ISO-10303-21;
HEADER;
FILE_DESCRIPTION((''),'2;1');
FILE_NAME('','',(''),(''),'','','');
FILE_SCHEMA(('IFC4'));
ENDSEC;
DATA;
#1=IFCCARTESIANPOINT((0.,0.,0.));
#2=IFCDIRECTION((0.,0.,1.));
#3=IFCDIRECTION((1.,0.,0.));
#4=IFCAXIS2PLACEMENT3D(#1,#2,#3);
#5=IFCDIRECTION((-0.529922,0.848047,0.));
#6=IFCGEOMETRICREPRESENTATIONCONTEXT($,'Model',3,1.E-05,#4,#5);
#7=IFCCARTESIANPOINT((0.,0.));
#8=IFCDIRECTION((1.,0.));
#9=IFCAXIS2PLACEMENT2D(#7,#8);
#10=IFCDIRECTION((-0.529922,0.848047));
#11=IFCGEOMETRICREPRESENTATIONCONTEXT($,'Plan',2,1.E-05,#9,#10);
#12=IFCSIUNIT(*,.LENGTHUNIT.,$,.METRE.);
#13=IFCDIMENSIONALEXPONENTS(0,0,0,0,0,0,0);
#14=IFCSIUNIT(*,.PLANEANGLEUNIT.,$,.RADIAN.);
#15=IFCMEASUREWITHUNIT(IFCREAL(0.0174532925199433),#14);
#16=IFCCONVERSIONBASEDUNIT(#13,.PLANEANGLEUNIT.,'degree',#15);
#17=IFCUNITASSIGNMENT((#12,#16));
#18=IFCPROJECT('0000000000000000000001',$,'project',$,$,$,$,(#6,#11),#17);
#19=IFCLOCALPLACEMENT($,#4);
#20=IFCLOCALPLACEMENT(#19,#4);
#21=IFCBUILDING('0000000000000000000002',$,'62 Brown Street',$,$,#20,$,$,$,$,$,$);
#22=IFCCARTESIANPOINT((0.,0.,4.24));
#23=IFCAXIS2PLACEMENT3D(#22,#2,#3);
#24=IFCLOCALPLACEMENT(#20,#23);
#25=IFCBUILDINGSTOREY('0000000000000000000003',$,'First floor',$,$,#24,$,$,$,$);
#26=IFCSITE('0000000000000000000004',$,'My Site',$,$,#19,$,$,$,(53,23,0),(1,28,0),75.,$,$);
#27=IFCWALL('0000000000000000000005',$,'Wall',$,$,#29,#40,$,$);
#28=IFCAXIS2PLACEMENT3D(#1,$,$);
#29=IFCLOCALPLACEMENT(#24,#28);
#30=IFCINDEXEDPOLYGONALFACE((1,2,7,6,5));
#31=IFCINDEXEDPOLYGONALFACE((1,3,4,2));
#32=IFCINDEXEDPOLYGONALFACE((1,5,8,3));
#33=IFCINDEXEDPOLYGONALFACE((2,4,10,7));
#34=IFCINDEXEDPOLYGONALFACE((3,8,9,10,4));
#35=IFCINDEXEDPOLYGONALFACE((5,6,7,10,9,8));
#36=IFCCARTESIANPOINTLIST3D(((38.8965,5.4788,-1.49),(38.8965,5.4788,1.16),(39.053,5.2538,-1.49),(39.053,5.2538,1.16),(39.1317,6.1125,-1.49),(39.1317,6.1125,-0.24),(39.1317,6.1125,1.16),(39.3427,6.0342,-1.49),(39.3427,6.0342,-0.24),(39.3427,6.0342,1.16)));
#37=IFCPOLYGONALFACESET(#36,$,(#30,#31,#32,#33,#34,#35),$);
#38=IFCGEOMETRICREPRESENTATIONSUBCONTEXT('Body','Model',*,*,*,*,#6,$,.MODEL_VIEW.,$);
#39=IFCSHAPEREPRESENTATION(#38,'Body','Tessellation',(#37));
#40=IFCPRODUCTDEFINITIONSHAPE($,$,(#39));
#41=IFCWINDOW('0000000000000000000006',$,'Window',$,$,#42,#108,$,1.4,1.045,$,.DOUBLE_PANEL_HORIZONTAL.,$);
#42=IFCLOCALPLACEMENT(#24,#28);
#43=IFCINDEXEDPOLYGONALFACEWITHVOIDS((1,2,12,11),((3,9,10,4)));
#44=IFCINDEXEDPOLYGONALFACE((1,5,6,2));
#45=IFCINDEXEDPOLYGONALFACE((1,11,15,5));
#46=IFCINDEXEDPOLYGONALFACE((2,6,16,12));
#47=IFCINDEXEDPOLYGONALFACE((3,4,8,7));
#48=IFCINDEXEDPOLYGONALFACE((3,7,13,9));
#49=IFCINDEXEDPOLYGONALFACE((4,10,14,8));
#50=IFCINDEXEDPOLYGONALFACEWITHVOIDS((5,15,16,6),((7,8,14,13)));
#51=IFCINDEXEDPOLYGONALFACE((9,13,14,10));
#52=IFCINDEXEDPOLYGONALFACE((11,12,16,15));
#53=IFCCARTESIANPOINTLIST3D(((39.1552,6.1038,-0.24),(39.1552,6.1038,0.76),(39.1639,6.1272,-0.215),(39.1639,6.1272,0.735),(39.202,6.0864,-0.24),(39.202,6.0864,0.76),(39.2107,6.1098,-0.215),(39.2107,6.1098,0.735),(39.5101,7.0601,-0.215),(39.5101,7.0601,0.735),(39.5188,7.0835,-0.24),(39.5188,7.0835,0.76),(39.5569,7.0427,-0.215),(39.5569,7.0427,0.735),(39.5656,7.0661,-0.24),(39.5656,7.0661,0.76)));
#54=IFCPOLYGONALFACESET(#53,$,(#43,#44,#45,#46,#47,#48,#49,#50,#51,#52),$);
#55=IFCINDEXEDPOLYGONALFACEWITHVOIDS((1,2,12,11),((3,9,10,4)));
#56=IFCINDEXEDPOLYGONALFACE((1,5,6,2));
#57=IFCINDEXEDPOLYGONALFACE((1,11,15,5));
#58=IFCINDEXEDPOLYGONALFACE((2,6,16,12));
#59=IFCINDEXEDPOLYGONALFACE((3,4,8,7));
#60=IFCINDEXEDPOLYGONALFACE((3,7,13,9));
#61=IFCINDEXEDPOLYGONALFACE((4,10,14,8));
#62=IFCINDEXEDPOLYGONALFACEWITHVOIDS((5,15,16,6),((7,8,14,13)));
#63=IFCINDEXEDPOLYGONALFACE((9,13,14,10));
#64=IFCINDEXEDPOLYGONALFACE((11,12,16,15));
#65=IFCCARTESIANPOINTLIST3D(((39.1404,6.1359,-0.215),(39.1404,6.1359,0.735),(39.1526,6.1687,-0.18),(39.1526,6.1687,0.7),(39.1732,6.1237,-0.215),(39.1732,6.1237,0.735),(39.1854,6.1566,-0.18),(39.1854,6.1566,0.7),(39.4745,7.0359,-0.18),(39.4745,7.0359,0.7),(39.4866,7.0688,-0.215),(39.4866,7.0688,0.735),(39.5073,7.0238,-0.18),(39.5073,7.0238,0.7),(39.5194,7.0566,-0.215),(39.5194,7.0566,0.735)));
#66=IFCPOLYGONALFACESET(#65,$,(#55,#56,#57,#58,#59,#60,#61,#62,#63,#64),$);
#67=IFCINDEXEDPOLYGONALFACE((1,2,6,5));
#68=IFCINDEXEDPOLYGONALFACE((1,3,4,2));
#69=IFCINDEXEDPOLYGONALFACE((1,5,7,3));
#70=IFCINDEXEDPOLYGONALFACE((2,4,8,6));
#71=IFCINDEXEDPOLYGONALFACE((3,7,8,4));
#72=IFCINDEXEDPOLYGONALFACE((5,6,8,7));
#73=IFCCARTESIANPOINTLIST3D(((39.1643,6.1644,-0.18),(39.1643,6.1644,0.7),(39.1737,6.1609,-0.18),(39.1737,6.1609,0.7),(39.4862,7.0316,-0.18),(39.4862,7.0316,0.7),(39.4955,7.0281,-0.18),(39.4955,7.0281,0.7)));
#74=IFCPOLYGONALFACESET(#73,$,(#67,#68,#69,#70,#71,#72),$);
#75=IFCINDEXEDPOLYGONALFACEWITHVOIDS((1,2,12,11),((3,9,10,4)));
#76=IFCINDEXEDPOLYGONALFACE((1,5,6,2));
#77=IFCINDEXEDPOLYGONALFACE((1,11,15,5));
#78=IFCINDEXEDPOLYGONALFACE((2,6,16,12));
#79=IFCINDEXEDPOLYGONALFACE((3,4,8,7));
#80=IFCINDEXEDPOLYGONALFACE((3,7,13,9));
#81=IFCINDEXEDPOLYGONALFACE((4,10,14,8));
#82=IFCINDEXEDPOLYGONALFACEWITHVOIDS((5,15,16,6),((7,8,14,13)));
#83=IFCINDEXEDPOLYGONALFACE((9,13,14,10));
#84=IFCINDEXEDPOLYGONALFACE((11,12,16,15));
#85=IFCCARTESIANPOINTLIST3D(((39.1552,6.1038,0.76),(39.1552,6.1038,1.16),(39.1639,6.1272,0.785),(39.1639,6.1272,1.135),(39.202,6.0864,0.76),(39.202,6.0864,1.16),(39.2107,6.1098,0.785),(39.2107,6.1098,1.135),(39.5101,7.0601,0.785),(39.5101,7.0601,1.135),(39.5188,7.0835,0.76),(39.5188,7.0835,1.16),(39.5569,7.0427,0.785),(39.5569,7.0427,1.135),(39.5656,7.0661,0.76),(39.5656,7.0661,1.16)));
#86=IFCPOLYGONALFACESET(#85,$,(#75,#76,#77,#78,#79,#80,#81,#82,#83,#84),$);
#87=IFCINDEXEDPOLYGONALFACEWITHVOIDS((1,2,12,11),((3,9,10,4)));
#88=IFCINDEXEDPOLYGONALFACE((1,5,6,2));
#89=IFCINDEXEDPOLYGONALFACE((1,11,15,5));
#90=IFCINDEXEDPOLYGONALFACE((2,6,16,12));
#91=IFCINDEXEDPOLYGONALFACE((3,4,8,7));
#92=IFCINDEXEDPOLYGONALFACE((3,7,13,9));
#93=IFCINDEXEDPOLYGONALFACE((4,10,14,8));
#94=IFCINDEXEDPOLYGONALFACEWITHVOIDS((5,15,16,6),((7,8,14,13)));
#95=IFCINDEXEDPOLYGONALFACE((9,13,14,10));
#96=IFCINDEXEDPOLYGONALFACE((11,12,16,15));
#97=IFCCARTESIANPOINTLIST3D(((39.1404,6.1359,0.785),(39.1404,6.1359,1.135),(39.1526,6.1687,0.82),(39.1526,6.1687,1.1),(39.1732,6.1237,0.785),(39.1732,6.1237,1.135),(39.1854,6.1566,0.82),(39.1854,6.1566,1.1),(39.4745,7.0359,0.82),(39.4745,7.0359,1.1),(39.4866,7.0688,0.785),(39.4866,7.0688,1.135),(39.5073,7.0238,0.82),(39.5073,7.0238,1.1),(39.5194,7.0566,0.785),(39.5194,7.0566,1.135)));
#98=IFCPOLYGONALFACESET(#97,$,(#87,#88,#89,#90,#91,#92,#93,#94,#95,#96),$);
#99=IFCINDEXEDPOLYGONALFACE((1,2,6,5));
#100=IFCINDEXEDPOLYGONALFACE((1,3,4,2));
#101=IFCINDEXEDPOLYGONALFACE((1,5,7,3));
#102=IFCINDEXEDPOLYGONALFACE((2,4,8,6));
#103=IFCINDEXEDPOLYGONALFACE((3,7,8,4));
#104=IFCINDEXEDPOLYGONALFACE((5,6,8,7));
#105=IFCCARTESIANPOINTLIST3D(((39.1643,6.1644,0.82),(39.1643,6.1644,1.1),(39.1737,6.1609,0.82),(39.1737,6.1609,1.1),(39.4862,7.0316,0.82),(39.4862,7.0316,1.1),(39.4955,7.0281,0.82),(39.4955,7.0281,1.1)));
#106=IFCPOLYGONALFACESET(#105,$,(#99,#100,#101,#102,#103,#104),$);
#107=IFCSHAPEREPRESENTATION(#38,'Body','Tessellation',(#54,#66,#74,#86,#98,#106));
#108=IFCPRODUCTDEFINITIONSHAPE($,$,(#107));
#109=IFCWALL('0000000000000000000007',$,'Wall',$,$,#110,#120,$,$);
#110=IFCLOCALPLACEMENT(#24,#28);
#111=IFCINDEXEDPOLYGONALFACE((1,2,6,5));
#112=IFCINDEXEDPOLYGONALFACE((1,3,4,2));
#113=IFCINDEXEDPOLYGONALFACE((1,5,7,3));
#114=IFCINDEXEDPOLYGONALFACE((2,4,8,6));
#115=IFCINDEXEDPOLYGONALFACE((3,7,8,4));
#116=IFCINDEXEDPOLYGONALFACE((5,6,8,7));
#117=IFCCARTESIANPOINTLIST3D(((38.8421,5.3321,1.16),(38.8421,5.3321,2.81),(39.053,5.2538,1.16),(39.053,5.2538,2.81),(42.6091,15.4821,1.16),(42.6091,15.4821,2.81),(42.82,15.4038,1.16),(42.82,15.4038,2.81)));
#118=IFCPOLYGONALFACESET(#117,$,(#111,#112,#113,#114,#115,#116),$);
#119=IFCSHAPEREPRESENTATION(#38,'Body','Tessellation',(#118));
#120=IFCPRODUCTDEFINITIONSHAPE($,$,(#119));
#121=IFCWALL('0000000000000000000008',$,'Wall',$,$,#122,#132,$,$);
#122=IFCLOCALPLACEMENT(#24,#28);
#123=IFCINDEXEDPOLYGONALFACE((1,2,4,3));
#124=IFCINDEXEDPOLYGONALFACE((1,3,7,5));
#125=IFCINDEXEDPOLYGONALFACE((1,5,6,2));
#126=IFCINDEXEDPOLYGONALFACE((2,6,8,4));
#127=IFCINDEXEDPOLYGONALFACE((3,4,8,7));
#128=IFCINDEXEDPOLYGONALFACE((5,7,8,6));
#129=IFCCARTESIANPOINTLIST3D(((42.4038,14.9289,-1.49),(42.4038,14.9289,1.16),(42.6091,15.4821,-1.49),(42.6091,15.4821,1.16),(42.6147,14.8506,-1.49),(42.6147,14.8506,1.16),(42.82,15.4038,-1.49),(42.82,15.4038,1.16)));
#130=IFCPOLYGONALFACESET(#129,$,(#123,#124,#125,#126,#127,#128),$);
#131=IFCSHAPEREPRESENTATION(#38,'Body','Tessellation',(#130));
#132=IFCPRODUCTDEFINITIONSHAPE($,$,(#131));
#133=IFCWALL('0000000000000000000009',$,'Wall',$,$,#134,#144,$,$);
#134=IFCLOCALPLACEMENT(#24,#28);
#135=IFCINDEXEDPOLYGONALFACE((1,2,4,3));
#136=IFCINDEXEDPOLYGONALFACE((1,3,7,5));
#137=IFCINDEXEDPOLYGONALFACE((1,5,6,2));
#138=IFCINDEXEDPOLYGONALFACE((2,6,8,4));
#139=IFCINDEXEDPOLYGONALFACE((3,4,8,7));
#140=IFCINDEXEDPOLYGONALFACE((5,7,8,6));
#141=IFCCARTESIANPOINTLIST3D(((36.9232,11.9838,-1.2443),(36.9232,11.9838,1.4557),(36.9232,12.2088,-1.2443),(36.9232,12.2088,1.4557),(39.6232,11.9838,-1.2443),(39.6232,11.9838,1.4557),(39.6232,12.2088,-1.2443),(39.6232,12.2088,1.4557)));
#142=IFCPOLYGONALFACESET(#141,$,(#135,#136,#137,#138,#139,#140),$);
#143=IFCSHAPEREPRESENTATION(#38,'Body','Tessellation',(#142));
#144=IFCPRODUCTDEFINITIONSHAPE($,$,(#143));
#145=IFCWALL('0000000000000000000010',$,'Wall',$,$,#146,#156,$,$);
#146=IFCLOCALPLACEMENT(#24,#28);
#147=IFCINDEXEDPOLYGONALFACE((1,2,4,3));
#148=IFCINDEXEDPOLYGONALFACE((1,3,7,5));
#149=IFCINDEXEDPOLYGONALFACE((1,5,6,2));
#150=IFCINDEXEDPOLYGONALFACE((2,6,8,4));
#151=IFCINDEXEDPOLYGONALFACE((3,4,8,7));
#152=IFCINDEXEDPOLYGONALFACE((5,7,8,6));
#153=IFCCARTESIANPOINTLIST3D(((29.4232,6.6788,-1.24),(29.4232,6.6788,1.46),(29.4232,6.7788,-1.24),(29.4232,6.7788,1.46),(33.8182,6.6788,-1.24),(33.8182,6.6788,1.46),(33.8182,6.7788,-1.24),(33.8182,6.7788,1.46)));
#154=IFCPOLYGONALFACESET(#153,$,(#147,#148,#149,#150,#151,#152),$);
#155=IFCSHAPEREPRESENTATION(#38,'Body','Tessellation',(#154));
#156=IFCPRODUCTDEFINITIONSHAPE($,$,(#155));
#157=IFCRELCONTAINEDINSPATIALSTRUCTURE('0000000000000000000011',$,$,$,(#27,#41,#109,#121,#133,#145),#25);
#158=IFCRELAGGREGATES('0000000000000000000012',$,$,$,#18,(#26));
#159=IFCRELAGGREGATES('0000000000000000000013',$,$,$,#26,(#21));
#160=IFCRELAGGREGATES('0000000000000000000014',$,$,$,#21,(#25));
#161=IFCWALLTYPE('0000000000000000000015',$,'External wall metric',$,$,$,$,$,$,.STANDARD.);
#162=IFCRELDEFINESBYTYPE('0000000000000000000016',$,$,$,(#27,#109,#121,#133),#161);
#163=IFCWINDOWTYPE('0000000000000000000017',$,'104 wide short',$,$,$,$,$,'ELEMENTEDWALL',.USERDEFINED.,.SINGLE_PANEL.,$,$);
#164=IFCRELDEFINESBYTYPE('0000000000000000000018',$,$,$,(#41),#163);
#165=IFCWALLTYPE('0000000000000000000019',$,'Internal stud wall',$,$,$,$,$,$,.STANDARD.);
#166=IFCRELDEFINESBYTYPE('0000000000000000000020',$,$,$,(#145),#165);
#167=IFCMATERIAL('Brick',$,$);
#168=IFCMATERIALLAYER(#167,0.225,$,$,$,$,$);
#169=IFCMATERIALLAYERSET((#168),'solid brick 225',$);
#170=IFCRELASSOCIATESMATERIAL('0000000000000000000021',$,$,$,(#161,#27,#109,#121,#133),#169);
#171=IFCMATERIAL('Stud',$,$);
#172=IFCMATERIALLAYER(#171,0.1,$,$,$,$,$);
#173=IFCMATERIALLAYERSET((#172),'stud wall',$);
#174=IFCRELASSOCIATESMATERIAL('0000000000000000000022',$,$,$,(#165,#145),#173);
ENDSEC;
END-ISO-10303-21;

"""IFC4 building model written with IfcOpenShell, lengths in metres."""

from ifc_helpers import new_model, entity, si_unit, converted_unit, direction, frame, origin_with_axes, origin_2d_with_axis, place, context, subcontext, project, spatial, line, indexed_curve, outline, extrude, clip, halfspace, shape, source, transform, mapped, material, layer, layer_set, layer_usage, type_object, type_shapes, element, fill, save


model = new_model("IFC4")

# Units and contexts
model_context = context("Model", 3, precision=1e-05, world=origin_with_axes(), true_north=direction((-0.529922, 0.848047, 0.0)))
plan_context = context("Plan", 2, precision=1e-05, world=origin_2d_with_axis(), true_north=direction((-0.529922, 0.848047)))
body_context_1 = subcontext(model_context, "Body", "Model", "MODEL_VIEW")
body_context_2 = subcontext(plan_context, "Body", "Plan", "PLAN_VIEW")
ifc_project = project(units=[si_unit("LENGTHUNIT", "METRE"), converted_unit("PLANEANGLEUNIT", "degree", entity("IfcReal", 0.0174532925199433), si_unit("PLANEANGLEUNIT", "RADIAN"), dimensions=[0, 0, 0, 0, 0, 0, 0])], contexts=[model_context, plan_context])

# Site, building, storey
site_placement = place(None, origin_with_axes())
site = spatial("IfcSite", under=ifc_project, at=site_placement, Name="My Site", RefLatitude=(53, 23, 0), RefLongitude=(1, 28, 0), RefElevation=75.0)
building_placement = place(site_placement, origin_with_axes())
building = spatial("IfcBuilding", under=site, at=building_placement, Name="62 Brown Street")
storey_placement = place(building_placement, frame((0.0, 0.0, 4.24), z_axis=(0.0, 0.0, 1.0), x_axis=(1.0, 0.0, 0.0)))
storey = spatial("IfcBuildingStorey", under=building, at=storey_placement, Name="First floor")

# Wall, opening, window
ifc_material_1 = material(Name="Brick")
ifc_layer_1 = layer(ifc_material_1, 0.225)
ifc_layer_set_1 = layer_set([ifc_layer_1], Name="solid brick 225")
ifc_layer_usage_1 = layer_usage(ifc_layer_set_1, "AXIS2", "POSITIVE", 0.0)
wall_type_1 = type_object("IfcWallType", Name="External wall metric", PredefinedType="STANDARD", material=ifc_layer_set_1)
wall_1_placement = place(storey_placement, frame((39.024, 5.1755, -1.49), z_axis=(0.0, 0.0, 1.0), x_axis=(0.347944, 0.937515, 0.0)))
wall_1 = element("IfcWall", 1, at=wall_1_placement, inside=storey, type_object=wall_type_1, material=ifc_layer_usage_1, Name="Wall", context=body_context_1, shape_type="Clipping", body=[
    clip(extrude(outline(indexed_curve([(0.0, 0.0), (0.0, 0.225), (0.9159, 0.225), (0.9159, 0.0), (0.0, 0.0)], self_intersect=False)), origin_with_axes(), (0.0, 0.0, 1.0), 2.65), halfspace(frame((0.0835, 0.0, -2.75), z_axis=(-0.596248, 0.414701, 0.0), x_axis=(0.156491, 0.224999, 0.0)), False)),
])
shared_shape_1 = source(origin_with_axes(), body_context_1, "Body", "SweptSolid", [
    extrude(outline(indexed_curve([(0.0, 0.0), (1.045, 0.0), (1.045, 1.4), (0.0, 1.4)], segments=[line(1, 2, 3, 4, 1)])), frame((0.0, -0.1, 0.0), z_axis=(0.0, -1.0, 0.0), x_axis=(1.0, 0.0, 0.0)), (0.0, 0.0, -1.0), 0.425),
])
opening_1_placement = place(wall_1_placement, frame((0.9159, 0.0, 1.25), z_axis=(0.0, 0.0, 1.0), x_axis=(1.0, 0.0, 0.0)))
opening_1 = element("IfcOpeningElement", 2, at=opening_1_placement, cuts=wall_1, PredefinedType="OPENING", context=body_context_1, shape_type="MappedRepresentation", body=[
    mapped(shared_shape_1, transform((0.0, 0.0, 0.0), x_axis=(1.0, 0.0, 0.0), y_axis=(0.0, 1.0, 0.0), z_axis=(0.0, 0.0, 1.0), scale=1.0)),
])
window_type_1 = type_object("IfcWindowType", Name="104 wide short", ElementType="ELEMENTEDWALL", PartitioningType="SINGLE_PANEL", PredefinedType="USERDEFINED")
shared_shape_2 = source(origin_with_axes(), body_context_1, "Body", "SweptSolid", [
    extrude(outline(indexed_curve([(0.0, 0.0), (1.045, 0.0), (1.045, 1.0), (0.0, 1.0)], segments=[line(1, 2, 3, 4, 1)]), holes=[indexed_curve([(0.025, 0.025), (1.02, 0.025), (1.02, 0.975), (0.025, 0.975)], segments=[line(1, 2, 3, 4, 1)])]), frame((0.0, 0.15, 0.0), z_axis=(0.0, -1.0, 0.0), x_axis=(1.0, 0.0, 0.0)), (0.0, 0.0, -1.0), 0.05),
    extrude(outline(indexed_curve([(0.0, 0.0), (0.995, 0.0), (0.995, 0.95), (0.0, 0.95)], segments=[line(1, 2, 3, 4, 1)]), holes=[indexed_curve([(0.035, 0.035), (0.96, 0.035), (0.96, 0.915), (0.035, 0.915)], segments=[line(1, 2, 3, 4, 1)])]), frame((0.025, 0.19, 0.025), z_axis=(0.0, -1.0, 0.0), x_axis=(1.0, 0.0, 0.0)), (0.0, 0.0, -1.0), 0.035),
    extrude(outline(indexed_curve([(0.035, 0.035), (0.96, 0.035), (0.96, 0.915), (0.035, 0.915)], segments=[line(1, 2, 3, 4, 1)])), frame((0.025, 0.2025, 0.025), z_axis=(0.0, -1.0, 0.0), x_axis=(1.0, 0.0, 0.0)), (0.0, 0.0, -1.0), 0.01),
    extrude(outline(indexed_curve([(0.0, 0.0), (1.045, 0.0), (1.045, 0.4), (0.0, 0.4)], segments=[line(1, 2, 3, 4, 1)]), holes=[indexed_curve([(0.025, 0.025), (1.02, 0.025), (1.02, 0.375), (0.025, 0.375)], segments=[line(1, 2, 3, 4, 1)])]), frame((0.0, 0.15, 1.0), z_axis=(0.0, -1.0, 0.0), x_axis=(1.0, 0.0, 0.0)), (0.0, 0.0, -1.0), 0.05),
    extrude(outline(indexed_curve([(0.0, 0.0), (0.995, 0.0), (0.995, 0.35), (0.0, 0.35)], segments=[line(1, 2, 3, 4, 1)]), holes=[indexed_curve([(0.035, 0.035), (0.96, 0.035), (0.96, 0.315), (0.035, 0.315)], segments=[line(1, 2, 3, 4, 1)])]), frame((0.025, 0.19, 1.025), z_axis=(0.0, -1.0, 0.0), x_axis=(1.0, 0.0, 0.0)), (0.0, 0.0, -1.0), 0.035),
    extrude(outline(indexed_curve([(0.035, 0.035), (0.96, 0.035), (0.96, 0.315), (0.035, 0.315)], segments=[line(1, 2, 3, 4, 1)])), frame((0.025, 0.2025, 1.025), z_axis=(0.0, -1.0, 0.0), x_axis=(1.0, 0.0, 0.0)), (0.0, 0.0, -1.0), 0.01),
])
shared_shape_3 = source(origin_with_axes(), body_context_2, "Body", "Curve2D", [
    entity("IfcIndexedPolyCurve", entity("IfcCartesianPointList2D", [[0.025, 0.15], [1.02, 0.15]])),
    entity("IfcIndexedPolyCurve", entity("IfcCartesianPointList2D", [[0.0, 0.2], [0.025, 0.2], [0.025, 0.15], [0.0, 0.15]]), [entity("IfcLineIndex", [1, 2, 3, 4, 1])]),
    entity("IfcIndexedPolyCurve", entity("IfcCartesianPointList2D", [[1.045, 0.2], [1.02, 0.2], [1.02, 0.15], [1.045, 0.15]]), [entity("IfcLineIndex", [1, 2, 3, 4, 1])]),
    entity("IfcIndexedPolyCurve", entity("IfcCartesianPointList2D", [[0.025, 0.19], [0.06, 0.19], [0.06, 0.225], [0.025, 0.225]]), [entity("IfcLineIndex", [1, 2, 3, 4, 1])]),
    entity("IfcIndexedPolyCurve", entity("IfcCartesianPointList2D", [[1.02, 0.19], [0.985, 0.19], [0.985, 0.225], [1.02, 0.225]]), [entity("IfcLineIndex", [1, 2, 3, 4, 1])]),
    entity("IfcIndexedPolyCurve", entity("IfcCartesianPointList2D", [[0.06, 0.19], [0.985, 0.19]])),
    entity("IfcIndexedPolyCurve", entity("IfcCartesianPointList2D", [[0.06, 0.225], [0.985, 0.225]])),
    entity("IfcIndexedPolyCurve", entity("IfcCartesianPointList2D", [[0.06, 0.2075], [0.985, 0.2075]])),
])
type_shapes(window_type_1, [shared_shape_2, shared_shape_3])
window_1_placement = place(opening_1_placement, frame((0.0, 0.0, 0.0), z_axis=(0.0, 0.0, 1.0), x_axis=(1.0, 0.0, 0.0)))
window_1 = element("IfcWindow", 3, at=window_1_placement, inside=storey, type_object=window_type_1, Name="Window", OverallHeight=1.4, OverallWidth=1.045, PartitioningType="DOUBLE_PANEL_HORIZONTAL", shapes=[
    shape(body_context_1, "Body", "MappedRepresentation", [mapped(shared_shape_2, transform((0.0, 0.0, 0.0), x_axis=(1.0, 0.0, 0.0), y_axis=(0.0, 1.0, 0.0), z_axis=(0.0, 0.0, 1.0), scale=1.0))]),
    shape(body_context_2, "Body", "MappedRepresentation", [mapped(shared_shape_3, transform((0.0, 0.0, 0.0), x_axis=(1.0, 0.0, 0.0), y_axis=(0.0, 1.0, 0.0), z_axis=(0.0, 0.0, 1.0), scale=1.0))]),
])
fill(opening_1, window_1)

# Walls
ifc_layer_usage_2 = layer_usage(ifc_layer_set_1, "AXIS2", "POSITIVE", 0.0)
wall_2_placement = place(storey_placement, frame((39.053, 5.2538, 1.16), z_axis=(0.0, 0.0, 1.0), x_axis=(0.347944, 0.937515, 0.0)))
element("IfcWall", 4, at=wall_2_placement, inside=storey, type_object=wall_type_1, material=ifc_layer_usage_2, Name="Wall", context=body_context_1, shape_type="SweptSolid", body=[
    extrude(outline(indexed_curve([(0.0, 0.0), (0.0, 0.225), (10.8265, 0.225), (10.8265, 0.0), (0.0, 0.0)], self_intersect=False)), origin_with_axes(), (0.0, 0.0, 1.0), 1.65),
])
ifc_layer_usage_3 = layer_usage(ifc_layer_set_1, "AXIS2", "POSITIVE", 0.0)
wall_3_placement = place(storey_placement, frame((42.6147, 14.8506, -1.49), z_axis=(0.0, 0.0, 1.0), x_axis=(0.347944, 0.937515, 0.0)))
element("IfcWall", 5, at=wall_3_placement, inside=storey, type_object=wall_type_1, material=ifc_layer_usage_3, Name="Wall", context=body_context_1, shape_type="SweptSolid", body=[
    extrude(outline(indexed_curve([(0.0, 0.0), (0.0, 0.225), (0.5901, 0.225), (0.5901, 0.0), (0.0, 0.0)], self_intersect=False)), origin_with_axes(), (0.0, 0.0, 1.0), 2.65),
])
ifc_layer_usage_4 = layer_usage(ifc_layer_set_1, "AXIS2", "POSITIVE", 0.0)
wall_4_placement = place(storey_placement, frame((36.9232, 11.9838, -1.2443), z_axis=(0.0, 0.0, 1.0), x_axis=(1.0, 0.0, 0.0)))
element("IfcWall", 6, at=wall_4_placement, inside=storey, type_object=wall_type_1, material=ifc_layer_usage_4, Name="Wall", context=body_context_1, shape_type="SweptSolid", body=[
    extrude(outline(indexed_curve([(0.0, 0.0), (0.0, 0.225), (2.7, 0.225), (2.7, 0.0), (0.0, 0.0)], self_intersect=False)), origin_with_axes(), (0.0, 0.0, 1.0), 2.7),
])

# Shared definitions
ifc_material_2 = material(Name="Stud")
ifc_layer_2 = layer(ifc_material_2, 0.1)
ifc_layer_set_2 = layer_set([ifc_layer_2], Name="stud wall")
wall_type_2 = type_object("IfcWallType", Name="Internal stud wall", PredefinedType="STANDARD", material=ifc_layer_set_2)

# Wall
ifc_layer_usage_5 = layer_usage(ifc_layer_set_2, "AXIS2", "POSITIVE", 0.0)
wall_5_placement = place(storey_placement, frame((33.8182, 6.7788, -1.24), z_axis=(0.0, 0.0, 1.0), x_axis=(-1.0, 0.000001, 0.0)))
element("IfcWall", 7, at=wall_5_placement, inside=storey, type_object=wall_type_2, material=ifc_layer_usage_5, Name="Wall", context=body_context_1, shape_type="SweptSolid", body=[
    extrude(outline(indexed_curve([(0.0, 0.0), (0.0, 0.1), (4.395, 0.1), (4.395, 0.0), (0.0, 0.0)], self_intersect=False)), origin_with_axes(), (0.0, 0.0, 1.0), 2.7),
])

save(model, "model.ifc")
